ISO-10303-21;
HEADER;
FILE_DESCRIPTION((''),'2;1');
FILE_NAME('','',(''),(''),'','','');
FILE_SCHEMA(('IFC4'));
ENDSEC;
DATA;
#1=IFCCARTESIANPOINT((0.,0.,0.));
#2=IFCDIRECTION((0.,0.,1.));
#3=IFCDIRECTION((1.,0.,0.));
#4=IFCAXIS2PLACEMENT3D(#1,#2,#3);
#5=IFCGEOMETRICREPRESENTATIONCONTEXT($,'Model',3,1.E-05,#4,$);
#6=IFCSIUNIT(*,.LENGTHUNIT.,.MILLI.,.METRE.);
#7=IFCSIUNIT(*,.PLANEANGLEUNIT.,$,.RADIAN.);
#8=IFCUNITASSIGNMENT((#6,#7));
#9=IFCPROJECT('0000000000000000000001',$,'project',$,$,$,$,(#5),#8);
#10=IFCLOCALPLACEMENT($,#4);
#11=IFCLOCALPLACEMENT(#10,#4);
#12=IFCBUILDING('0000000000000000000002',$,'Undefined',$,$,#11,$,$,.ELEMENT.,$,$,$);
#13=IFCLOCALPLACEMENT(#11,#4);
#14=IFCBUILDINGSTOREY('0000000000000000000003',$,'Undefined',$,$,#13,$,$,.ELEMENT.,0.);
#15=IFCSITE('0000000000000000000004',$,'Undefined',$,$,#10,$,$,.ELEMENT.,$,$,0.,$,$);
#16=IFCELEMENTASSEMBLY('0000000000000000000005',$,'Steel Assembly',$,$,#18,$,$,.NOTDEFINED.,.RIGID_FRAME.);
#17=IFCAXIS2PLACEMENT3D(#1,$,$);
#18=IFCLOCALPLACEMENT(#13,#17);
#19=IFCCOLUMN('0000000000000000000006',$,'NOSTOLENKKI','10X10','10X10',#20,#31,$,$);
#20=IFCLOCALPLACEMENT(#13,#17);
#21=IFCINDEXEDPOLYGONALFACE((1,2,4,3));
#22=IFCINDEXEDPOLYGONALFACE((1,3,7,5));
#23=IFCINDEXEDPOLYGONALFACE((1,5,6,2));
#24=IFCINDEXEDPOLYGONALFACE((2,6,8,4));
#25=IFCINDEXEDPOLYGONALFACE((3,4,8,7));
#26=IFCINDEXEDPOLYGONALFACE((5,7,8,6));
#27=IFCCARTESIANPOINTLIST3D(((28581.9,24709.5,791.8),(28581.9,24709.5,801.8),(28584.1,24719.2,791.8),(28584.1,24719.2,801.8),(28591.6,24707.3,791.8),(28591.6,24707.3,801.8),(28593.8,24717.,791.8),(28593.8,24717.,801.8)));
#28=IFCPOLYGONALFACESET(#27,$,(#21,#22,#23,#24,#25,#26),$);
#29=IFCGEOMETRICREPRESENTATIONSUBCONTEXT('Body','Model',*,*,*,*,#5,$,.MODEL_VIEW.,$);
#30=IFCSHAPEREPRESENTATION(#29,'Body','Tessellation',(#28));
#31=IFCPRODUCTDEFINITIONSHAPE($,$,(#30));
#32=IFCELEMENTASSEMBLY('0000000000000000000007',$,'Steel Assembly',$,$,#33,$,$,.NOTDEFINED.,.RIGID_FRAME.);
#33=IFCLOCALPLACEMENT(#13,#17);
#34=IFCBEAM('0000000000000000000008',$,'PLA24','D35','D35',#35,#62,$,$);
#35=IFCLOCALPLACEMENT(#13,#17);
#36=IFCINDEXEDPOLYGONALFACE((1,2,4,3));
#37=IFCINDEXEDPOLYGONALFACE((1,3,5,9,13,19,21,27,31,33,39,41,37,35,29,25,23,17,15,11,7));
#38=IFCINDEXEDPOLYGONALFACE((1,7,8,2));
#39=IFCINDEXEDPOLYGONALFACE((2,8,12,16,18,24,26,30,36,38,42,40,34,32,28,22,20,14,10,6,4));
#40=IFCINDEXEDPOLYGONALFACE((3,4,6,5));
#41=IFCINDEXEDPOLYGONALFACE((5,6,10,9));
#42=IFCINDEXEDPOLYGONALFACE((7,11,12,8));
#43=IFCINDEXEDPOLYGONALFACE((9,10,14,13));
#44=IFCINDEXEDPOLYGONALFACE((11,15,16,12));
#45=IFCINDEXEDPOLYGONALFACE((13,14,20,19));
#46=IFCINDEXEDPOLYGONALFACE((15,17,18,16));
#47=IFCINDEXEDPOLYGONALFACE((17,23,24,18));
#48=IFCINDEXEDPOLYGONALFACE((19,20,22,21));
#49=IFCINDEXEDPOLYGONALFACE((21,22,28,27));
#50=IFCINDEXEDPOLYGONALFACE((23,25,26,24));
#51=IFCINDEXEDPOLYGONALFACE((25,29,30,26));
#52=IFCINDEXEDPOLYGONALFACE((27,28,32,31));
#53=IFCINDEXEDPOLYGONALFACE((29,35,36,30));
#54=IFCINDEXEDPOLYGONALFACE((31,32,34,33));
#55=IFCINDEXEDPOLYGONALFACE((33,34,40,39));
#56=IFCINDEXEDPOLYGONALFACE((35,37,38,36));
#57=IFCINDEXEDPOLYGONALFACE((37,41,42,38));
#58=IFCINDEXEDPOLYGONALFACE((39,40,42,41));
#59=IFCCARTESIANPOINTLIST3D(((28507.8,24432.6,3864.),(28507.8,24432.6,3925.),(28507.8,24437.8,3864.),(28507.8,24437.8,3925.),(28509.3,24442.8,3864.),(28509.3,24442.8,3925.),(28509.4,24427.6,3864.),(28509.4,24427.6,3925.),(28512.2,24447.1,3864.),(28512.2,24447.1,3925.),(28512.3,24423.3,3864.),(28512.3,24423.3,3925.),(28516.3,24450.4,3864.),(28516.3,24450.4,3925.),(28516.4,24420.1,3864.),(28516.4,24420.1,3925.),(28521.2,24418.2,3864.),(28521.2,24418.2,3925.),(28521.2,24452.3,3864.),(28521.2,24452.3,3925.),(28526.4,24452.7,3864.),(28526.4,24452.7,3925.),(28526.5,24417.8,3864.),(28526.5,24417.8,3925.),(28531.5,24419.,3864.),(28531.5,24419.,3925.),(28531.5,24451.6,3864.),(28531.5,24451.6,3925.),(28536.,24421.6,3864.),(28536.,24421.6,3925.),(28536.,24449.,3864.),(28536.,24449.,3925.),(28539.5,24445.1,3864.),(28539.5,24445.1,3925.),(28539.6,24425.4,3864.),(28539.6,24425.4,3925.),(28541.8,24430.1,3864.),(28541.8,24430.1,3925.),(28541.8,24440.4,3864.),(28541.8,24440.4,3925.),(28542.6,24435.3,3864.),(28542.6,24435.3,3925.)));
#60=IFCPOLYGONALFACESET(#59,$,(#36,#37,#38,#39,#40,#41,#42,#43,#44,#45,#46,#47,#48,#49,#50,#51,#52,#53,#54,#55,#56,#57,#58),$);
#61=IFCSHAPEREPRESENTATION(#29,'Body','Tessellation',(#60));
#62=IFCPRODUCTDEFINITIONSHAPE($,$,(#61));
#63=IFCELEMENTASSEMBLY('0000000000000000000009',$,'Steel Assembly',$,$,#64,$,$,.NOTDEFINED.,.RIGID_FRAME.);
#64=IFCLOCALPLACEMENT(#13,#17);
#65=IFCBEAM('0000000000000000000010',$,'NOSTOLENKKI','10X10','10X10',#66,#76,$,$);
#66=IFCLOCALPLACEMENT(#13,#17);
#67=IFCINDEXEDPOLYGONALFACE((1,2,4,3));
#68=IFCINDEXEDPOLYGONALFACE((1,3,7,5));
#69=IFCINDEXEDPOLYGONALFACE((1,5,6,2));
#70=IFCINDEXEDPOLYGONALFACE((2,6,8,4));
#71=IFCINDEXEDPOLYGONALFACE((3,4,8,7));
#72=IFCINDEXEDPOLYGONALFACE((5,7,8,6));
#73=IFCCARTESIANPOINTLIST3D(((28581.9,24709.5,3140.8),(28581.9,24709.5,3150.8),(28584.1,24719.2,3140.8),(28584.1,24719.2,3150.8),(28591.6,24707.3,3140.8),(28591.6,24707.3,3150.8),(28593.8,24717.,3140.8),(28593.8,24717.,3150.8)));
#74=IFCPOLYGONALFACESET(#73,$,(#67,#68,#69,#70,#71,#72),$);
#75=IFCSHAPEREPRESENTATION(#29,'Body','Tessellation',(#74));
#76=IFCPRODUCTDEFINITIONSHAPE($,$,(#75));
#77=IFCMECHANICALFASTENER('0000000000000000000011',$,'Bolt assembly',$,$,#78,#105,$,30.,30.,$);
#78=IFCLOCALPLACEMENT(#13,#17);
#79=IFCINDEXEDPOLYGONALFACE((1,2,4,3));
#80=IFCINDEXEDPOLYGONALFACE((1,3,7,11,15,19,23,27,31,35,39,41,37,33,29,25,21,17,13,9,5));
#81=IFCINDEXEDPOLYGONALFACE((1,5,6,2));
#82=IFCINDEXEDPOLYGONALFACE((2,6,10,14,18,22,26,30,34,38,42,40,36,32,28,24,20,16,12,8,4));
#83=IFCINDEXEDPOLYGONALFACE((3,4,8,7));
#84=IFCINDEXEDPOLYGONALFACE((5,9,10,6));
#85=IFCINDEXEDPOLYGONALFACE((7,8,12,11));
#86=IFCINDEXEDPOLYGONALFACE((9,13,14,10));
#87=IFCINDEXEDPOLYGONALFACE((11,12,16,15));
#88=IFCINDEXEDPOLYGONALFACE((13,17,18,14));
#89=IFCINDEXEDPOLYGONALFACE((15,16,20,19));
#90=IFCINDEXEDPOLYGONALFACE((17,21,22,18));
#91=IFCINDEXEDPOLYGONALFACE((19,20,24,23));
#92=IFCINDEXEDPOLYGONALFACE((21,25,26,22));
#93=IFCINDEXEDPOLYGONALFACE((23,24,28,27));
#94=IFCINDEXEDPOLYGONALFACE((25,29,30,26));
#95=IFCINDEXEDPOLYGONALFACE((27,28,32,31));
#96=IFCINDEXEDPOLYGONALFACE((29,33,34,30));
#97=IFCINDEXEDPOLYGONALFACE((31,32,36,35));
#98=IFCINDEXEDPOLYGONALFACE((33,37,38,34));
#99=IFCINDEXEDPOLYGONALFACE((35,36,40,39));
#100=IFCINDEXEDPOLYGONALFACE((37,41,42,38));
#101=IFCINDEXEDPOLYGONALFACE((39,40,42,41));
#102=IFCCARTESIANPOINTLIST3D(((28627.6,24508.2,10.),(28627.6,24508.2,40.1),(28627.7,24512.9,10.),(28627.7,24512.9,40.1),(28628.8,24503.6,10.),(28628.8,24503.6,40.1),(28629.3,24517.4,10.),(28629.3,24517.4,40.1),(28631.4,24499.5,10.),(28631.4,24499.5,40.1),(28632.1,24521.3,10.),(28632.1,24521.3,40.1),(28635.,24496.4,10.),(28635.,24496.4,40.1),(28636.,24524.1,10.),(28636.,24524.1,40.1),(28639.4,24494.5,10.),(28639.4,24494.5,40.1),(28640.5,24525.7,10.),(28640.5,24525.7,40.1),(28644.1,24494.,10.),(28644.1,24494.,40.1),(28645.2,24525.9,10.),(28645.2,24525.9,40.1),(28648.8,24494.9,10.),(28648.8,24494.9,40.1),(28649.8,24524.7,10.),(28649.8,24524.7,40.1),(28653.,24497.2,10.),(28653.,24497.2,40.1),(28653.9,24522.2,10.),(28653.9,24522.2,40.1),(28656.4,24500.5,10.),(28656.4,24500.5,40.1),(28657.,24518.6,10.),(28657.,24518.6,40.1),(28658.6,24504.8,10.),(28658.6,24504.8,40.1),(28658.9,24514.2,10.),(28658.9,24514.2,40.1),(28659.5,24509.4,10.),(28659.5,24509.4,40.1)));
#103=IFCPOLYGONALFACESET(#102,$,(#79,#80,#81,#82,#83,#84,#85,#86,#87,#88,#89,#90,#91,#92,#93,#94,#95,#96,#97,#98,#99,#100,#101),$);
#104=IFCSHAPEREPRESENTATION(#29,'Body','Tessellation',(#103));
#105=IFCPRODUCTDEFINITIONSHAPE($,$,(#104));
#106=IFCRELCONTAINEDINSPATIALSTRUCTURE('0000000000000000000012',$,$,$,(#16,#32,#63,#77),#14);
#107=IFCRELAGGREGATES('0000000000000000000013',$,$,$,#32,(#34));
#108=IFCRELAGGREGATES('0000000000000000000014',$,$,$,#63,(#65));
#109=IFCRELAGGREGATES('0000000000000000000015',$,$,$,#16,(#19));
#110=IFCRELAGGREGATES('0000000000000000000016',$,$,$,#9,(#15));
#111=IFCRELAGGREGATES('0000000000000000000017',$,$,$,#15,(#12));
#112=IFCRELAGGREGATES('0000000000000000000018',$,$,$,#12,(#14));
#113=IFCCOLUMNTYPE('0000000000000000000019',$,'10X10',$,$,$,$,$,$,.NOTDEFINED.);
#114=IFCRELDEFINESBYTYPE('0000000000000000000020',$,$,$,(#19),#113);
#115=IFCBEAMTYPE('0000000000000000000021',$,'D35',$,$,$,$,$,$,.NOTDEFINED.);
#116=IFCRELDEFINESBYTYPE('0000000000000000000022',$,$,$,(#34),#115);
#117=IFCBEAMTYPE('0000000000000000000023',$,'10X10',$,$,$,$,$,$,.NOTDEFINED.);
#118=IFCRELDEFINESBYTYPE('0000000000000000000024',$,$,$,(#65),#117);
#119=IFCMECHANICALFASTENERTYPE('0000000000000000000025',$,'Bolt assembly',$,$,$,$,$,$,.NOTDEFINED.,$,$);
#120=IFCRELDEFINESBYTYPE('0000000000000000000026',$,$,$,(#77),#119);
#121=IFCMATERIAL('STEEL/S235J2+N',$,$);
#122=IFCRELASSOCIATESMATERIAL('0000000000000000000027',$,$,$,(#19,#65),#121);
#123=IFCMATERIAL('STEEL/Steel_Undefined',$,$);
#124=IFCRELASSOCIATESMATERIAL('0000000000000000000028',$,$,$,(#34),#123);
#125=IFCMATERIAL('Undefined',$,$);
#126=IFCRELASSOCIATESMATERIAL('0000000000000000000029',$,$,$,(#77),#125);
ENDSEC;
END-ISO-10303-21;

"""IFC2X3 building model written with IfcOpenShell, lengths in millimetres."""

from ifc_helpers import new_model, si_unit, frame, origin_with_axes, origin_2d_with_axis, place, context, subcontext, project, spatial, rectangle, circle, extrude, source, transform, mapped, material, type_object, element, aggregate, save


model = new_model("IFC2X3")

# Units and contexts
model_context = context("Model", 3, precision=1e-05, world=origin_with_axes())
body_context = subcontext(model_context, "Body", "Model", "MODEL_VIEW")
ifc_project = project(units=[si_unit("LENGTHUNIT", "METRE", prefix="MILLI"), si_unit("PLANEANGLEUNIT", "RADIAN")], contexts=[model_context])

# Site, building, storey
site_placement = place(None, origin_with_axes())
site = spatial("IfcSite", under=ifc_project, at=site_placement, Name="Undefined", CompositionType="ELEMENT", RefElevation=0.0)
building_placement = place(site_placement, origin_with_axes())
building = spatial("IfcBuilding", under=site, at=building_placement, Name="Undefined", CompositionType="ELEMENT")
storey_placement = place(building_placement, origin_with_axes())
storey = spatial("IfcBuildingStorey", under=building, at=storey_placement, Name="Undefined", CompositionType="ELEMENT", Elevation=0.0)

# Element assembly, column
assembly_1_placement = place(storey_placement, origin_with_axes())
assembly_1 = element("IfcElementAssembly", 1, at=assembly_1_placement, inside=storey, Name="Steel Assembly", AssemblyPlace="NOTDEFINED", PredefinedType="RIGID_FRAME")
ifc_material_1 = material(Name="STEEL/S235J2+N")
column_type = type_object("IfcColumnType", Name="10X10", PredefinedType="NOTDEFINED")
column_placement = place(assembly_1_placement, frame((28587.9, 24713.2, 791.8), z_axis=(0.0, 0.0, 1.0), x_axis=(0.220227, 0.975449, 0.0)))
column = element("IfcColumn", 2, at=column_placement, type_object=column_type, material=ifc_material_1, Name="NOSTOLENKKI", Description="10X10", ObjectType="10X10", context=body_context, shape_type="SweptSolid", body=[
    extrude(rectangle(XDim=10.0, YDim=10.0, at=origin_2d_with_axis()), frame((0.0, 0.0, 10.0), z_axis=(0.0, 0.0, -1.0), x_axis=(0.0, 1.0, 0.0)), (0.0, 0.0, 1.0), 10.0),
])

# Element assemblies, beams
assembly_2_placement = place(storey_placement, origin_with_axes())
assembly_2 = element("IfcElementAssembly", 3, at=assembly_2_placement, inside=storey, Name="Steel Assembly", AssemblyPlace="NOTDEFINED", PredefinedType="RIGID_FRAME")
ifc_material_2 = material(Name="STEEL/Steel_Undefined")
beam_type_1 = type_object("IfcBeamType", Name="D35", PredefinedType="NOTDEFINED")
beam_1_placement = place(assembly_2_placement, frame((28525.1, 24435.2, 3925.0), z_axis=(0.975449, -0.220227, 0.0), x_axis=(0.0, 0.0, -1.0)))
beam_1 = element("IfcBeam", 4, at=beam_1_placement, type_object=beam_type_1, material=ifc_material_2, Name="PLA24", Description="D35", ObjectType="D35", context=body_context, shape_type="SweptSolid", body=[
    extrude(circle(Radius=17.5, at=origin_2d_with_axis()), frame((61.0, 0.0, 0.0), z_axis=(-1.0, 0.0, 0.0), x_axis=(0.0, -1.0, 0.0)), (0.0, 0.0, 1.0), 61.0),
])
assembly_3_placement = place(storey_placement, origin_with_axes())
assembly_3 = element("IfcElementAssembly", 5, at=assembly_3_placement, inside=storey, Name="Steel Assembly", AssemblyPlace="NOTDEFINED", PredefinedType="RIGID_FRAME")
beam_type_2 = type_object("IfcBeamType", Name="10X10", PredefinedType="NOTDEFINED")
beam_2_placement = place(assembly_3_placement, frame((28587.9, 24713.2, 3150.8), z_axis=(0.220227, 0.975449, 0.0), x_axis=(0.0, 0.0, -1.0)))
beam_2 = element("IfcBeam", 6, at=beam_2_placement, type_object=beam_type_2, material=ifc_material_1, Name="NOSTOLENKKI", Description="10X10", ObjectType="10X10", context=body_context, shape_type="SweptSolid", body=[
    extrude(rectangle(XDim=10.0, YDim=10.0, at=origin_2d_with_axis()), frame((10.0, 0.0, 0.0), z_axis=(-1.0, 0.0, 0.0), x_axis=(0.0, -1.0, 0.0)), (0.0, 0.0, 1.0), 10.0),
])

# Shared definitions
ifc_material_3 = material(Name="Undefined")
aggregate(assembly_2, [beam_1])
aggregate(assembly_3, [beam_2])
aggregate(assembly_1, [column])

# Mechanical fastener
mechanical_fastener_type = type_object("IfcMechanicalFastenerType", Name="Bolt assembly")
shared_shape_1 = source(origin_with_axes(), body_context, "Body", "SweptSolid", [
    extrude(circle(Radius=16.0, at=origin_2d_with_axis()), frame((0.0, 0.0, 0.0), z_axis=(0.0, 1.0, 0.0), x_axis=(1.0, 0.0, 0.0)), (0.0, 0.0, 1.0), 30.1),
])
for number, where, z_axis, x_axis, name in (
    (7, (28643.5, 24510.0, 10.0), (0.534023, -0.84547, 0.0), (0.84547, 0.534023, 0.0), "Bolt assembly"),
):
    element("IfcMechanicalFastener", number, at=place(storey_placement, frame(where, z_axis=z_axis, x_axis=x_axis)), inside=storey, type_object=mechanical_fastener_type, material=ifc_material_3, Name=name, NominalDiameter=30.0, NominalLength=30.0, context=body_context, shape_type="MappedRepresentation", body=[
        mapped(shared_shape_1, transform((0.0, 0.0, 0.0))),
    ])

save(model, "model.ifc")
